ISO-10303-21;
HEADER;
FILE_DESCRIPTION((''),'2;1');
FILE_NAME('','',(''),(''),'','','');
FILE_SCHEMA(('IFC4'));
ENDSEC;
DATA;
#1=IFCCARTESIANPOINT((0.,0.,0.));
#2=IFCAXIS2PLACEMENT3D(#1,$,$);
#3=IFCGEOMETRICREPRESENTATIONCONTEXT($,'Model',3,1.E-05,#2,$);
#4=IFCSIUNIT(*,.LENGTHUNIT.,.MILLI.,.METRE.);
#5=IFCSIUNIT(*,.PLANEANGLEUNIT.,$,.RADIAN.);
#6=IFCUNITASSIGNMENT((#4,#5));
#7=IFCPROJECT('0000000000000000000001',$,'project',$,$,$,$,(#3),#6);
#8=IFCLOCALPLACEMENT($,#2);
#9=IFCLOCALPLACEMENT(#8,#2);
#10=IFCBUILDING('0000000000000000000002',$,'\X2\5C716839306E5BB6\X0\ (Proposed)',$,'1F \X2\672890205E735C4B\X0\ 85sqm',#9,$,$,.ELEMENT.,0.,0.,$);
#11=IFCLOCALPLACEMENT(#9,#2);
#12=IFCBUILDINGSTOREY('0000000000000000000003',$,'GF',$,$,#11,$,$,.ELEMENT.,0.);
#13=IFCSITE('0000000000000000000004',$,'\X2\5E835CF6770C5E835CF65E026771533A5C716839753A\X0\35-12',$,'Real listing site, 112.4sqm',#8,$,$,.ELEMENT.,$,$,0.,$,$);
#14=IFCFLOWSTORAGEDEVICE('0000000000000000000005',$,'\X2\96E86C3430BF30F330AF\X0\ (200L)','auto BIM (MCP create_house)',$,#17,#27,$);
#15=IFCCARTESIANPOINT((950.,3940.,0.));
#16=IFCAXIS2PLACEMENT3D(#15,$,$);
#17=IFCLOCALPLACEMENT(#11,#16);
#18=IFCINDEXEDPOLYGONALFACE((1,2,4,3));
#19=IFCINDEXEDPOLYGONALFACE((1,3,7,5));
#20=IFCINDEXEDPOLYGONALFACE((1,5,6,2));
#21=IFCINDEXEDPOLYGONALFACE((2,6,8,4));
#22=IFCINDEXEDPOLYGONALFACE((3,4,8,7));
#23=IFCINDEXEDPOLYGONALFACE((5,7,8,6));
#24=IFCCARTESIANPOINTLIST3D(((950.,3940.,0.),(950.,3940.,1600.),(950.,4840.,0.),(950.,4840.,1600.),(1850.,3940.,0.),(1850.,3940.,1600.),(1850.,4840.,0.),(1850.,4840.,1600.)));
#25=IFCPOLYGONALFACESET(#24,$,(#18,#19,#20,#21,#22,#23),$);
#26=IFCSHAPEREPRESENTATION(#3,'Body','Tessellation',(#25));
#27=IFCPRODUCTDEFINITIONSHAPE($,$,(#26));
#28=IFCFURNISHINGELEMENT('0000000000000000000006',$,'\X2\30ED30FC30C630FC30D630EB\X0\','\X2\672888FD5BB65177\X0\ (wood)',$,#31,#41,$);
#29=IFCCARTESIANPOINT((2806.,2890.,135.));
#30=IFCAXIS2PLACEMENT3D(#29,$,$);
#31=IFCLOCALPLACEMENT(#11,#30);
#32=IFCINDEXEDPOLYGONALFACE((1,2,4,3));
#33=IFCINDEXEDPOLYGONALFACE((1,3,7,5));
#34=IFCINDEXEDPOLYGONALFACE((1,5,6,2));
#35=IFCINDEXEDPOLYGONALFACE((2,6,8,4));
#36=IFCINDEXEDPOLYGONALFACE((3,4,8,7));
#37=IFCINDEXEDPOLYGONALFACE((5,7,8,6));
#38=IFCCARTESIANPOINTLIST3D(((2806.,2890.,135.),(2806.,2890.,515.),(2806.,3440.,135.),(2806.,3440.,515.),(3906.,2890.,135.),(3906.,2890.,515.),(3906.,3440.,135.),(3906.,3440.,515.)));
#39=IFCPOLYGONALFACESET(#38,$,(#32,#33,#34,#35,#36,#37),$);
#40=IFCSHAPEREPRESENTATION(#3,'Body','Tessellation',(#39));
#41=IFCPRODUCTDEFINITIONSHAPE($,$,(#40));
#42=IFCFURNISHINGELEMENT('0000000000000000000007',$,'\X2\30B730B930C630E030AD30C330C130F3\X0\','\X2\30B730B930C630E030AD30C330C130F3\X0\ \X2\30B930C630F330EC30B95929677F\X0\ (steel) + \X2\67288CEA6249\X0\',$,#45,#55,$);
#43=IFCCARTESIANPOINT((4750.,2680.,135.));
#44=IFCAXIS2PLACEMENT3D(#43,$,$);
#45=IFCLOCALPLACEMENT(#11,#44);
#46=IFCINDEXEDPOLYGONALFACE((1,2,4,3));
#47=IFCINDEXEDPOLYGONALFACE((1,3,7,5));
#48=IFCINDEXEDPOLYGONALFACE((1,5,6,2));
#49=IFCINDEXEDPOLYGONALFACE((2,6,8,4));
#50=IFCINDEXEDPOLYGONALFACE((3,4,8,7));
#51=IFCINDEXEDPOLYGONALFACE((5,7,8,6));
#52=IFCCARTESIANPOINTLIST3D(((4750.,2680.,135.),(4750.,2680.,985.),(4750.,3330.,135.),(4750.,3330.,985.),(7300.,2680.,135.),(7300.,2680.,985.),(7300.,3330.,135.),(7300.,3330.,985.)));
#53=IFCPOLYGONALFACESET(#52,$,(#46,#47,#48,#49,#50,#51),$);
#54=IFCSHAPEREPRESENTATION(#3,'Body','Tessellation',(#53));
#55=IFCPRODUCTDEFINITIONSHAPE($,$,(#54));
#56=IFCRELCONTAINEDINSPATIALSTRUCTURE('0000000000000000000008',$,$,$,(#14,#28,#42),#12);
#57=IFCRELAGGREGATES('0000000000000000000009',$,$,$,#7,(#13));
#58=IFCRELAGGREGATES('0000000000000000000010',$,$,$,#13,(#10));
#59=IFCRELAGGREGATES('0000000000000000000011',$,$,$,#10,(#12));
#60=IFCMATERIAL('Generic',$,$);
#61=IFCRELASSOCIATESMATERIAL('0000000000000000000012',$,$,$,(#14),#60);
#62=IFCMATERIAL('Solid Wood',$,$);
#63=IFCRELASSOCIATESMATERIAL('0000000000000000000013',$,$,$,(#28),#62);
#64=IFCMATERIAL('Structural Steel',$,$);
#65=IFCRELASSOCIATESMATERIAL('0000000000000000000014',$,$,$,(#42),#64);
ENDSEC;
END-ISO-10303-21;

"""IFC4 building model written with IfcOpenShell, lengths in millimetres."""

from ifc_helpers import new_model, si_unit, frame, frame_2d, origin, place, context, project, spatial, rectangle, extrude, material, element, save


model = new_model("IFC4")

# Units and contexts
model_context = context("Model", 3, precision=1e-05, world=origin())
ifc_project = project(units=[si_unit("LENGTHUNIT", "METRE", prefix="MILLI"), si_unit("PLANEANGLEUNIT", "RADIAN")], contexts=[model_context])

# Site, building, storey
site_placement = place(None, origin())
site = spatial("IfcSite", under=ifc_project, at=site_placement, Name="広島県広島市東区山根町35-12", ObjectType="Real listing site, 112.4sqm", CompositionType="ELEMENT", RefElevation=0.0)
building_placement = place(site_placement, origin())
building = spatial("IfcBuilding", under=site, at=building_placement, Name="山根の家 (Proposed)", ObjectType="1F 木造平屋 85sqm", CompositionType="ELEMENT", ElevationOfRefHeight=0.0, ElevationOfTerrain=0.0)
storey_placement = place(building_placement, origin())
storey = spatial("IfcBuildingStorey", under=building, at=storey_placement, Name="GF", CompositionType="ELEMENT", Elevation=0.0)

# Shared definitions
ifc_material_1 = material(Name="Solid Wood")

# Shared definitions
ifc_material_2 = material(Name="Generic")

# Flow storage device
flow_storage_device_placement = place(storey_placement, frame((950.0, 3940.0, 0.0)))
element("IfcFlowStorageDevice", 1, at=flow_storage_device_placement, inside=storey, material=ifc_material_2, Name="雨水タンク (200L)", Description="auto BIM (MCP create_house)", context=model_context, shape_type="SweptSolid", body=[
    extrude(rectangle(XDim=900.0, YDim=900.0, at=frame_2d((450.0, 450.0))), frame((950.0, 3940.0, 0.0)), (0.0, 0.0, 1.0), 1600.0),
])

# Furnishing elements
furnishing_1_placement = place(storey_placement, frame((2806.0, 2890.0, 135.0)))
element("IfcFurnishingElement", 2, at=furnishing_1_placement, inside=storey, material=ifc_material_1, Name="ローテーブル", Description="木製家具 (wood)", context=model_context, shape_type="SweptSolid", body=[
    extrude(rectangle(XDim=1100.0, YDim=550.0, at=frame_2d((550.0, 275.0))), frame((2806.0, 2890.0, 135.0)), (0.0, 0.0, 1.0), 380.0),
])
ifc_material_3 = material(Name="Structural Steel")
furnishing_2_placement = place(storey_placement, frame((4750.0, 2680.0, 135.0)))
element("IfcFurnishingElement", 3, at=furnishing_2_placement, inside=storey, material=ifc_material_3, Name="システムキッチン", Description="システムキッチン ステンレス天板 (steel) + 木質扉", context=model_context, shape_type="SweptSolid", body=[
    extrude(rectangle(XDim=2550.0, YDim=650.0, at=frame_2d((1275.0, 325.0))), frame((4750.0, 2680.0, 135.0)), (0.0, 0.0, 1.0), 850.0),
])

save(model, "model.ifc")
